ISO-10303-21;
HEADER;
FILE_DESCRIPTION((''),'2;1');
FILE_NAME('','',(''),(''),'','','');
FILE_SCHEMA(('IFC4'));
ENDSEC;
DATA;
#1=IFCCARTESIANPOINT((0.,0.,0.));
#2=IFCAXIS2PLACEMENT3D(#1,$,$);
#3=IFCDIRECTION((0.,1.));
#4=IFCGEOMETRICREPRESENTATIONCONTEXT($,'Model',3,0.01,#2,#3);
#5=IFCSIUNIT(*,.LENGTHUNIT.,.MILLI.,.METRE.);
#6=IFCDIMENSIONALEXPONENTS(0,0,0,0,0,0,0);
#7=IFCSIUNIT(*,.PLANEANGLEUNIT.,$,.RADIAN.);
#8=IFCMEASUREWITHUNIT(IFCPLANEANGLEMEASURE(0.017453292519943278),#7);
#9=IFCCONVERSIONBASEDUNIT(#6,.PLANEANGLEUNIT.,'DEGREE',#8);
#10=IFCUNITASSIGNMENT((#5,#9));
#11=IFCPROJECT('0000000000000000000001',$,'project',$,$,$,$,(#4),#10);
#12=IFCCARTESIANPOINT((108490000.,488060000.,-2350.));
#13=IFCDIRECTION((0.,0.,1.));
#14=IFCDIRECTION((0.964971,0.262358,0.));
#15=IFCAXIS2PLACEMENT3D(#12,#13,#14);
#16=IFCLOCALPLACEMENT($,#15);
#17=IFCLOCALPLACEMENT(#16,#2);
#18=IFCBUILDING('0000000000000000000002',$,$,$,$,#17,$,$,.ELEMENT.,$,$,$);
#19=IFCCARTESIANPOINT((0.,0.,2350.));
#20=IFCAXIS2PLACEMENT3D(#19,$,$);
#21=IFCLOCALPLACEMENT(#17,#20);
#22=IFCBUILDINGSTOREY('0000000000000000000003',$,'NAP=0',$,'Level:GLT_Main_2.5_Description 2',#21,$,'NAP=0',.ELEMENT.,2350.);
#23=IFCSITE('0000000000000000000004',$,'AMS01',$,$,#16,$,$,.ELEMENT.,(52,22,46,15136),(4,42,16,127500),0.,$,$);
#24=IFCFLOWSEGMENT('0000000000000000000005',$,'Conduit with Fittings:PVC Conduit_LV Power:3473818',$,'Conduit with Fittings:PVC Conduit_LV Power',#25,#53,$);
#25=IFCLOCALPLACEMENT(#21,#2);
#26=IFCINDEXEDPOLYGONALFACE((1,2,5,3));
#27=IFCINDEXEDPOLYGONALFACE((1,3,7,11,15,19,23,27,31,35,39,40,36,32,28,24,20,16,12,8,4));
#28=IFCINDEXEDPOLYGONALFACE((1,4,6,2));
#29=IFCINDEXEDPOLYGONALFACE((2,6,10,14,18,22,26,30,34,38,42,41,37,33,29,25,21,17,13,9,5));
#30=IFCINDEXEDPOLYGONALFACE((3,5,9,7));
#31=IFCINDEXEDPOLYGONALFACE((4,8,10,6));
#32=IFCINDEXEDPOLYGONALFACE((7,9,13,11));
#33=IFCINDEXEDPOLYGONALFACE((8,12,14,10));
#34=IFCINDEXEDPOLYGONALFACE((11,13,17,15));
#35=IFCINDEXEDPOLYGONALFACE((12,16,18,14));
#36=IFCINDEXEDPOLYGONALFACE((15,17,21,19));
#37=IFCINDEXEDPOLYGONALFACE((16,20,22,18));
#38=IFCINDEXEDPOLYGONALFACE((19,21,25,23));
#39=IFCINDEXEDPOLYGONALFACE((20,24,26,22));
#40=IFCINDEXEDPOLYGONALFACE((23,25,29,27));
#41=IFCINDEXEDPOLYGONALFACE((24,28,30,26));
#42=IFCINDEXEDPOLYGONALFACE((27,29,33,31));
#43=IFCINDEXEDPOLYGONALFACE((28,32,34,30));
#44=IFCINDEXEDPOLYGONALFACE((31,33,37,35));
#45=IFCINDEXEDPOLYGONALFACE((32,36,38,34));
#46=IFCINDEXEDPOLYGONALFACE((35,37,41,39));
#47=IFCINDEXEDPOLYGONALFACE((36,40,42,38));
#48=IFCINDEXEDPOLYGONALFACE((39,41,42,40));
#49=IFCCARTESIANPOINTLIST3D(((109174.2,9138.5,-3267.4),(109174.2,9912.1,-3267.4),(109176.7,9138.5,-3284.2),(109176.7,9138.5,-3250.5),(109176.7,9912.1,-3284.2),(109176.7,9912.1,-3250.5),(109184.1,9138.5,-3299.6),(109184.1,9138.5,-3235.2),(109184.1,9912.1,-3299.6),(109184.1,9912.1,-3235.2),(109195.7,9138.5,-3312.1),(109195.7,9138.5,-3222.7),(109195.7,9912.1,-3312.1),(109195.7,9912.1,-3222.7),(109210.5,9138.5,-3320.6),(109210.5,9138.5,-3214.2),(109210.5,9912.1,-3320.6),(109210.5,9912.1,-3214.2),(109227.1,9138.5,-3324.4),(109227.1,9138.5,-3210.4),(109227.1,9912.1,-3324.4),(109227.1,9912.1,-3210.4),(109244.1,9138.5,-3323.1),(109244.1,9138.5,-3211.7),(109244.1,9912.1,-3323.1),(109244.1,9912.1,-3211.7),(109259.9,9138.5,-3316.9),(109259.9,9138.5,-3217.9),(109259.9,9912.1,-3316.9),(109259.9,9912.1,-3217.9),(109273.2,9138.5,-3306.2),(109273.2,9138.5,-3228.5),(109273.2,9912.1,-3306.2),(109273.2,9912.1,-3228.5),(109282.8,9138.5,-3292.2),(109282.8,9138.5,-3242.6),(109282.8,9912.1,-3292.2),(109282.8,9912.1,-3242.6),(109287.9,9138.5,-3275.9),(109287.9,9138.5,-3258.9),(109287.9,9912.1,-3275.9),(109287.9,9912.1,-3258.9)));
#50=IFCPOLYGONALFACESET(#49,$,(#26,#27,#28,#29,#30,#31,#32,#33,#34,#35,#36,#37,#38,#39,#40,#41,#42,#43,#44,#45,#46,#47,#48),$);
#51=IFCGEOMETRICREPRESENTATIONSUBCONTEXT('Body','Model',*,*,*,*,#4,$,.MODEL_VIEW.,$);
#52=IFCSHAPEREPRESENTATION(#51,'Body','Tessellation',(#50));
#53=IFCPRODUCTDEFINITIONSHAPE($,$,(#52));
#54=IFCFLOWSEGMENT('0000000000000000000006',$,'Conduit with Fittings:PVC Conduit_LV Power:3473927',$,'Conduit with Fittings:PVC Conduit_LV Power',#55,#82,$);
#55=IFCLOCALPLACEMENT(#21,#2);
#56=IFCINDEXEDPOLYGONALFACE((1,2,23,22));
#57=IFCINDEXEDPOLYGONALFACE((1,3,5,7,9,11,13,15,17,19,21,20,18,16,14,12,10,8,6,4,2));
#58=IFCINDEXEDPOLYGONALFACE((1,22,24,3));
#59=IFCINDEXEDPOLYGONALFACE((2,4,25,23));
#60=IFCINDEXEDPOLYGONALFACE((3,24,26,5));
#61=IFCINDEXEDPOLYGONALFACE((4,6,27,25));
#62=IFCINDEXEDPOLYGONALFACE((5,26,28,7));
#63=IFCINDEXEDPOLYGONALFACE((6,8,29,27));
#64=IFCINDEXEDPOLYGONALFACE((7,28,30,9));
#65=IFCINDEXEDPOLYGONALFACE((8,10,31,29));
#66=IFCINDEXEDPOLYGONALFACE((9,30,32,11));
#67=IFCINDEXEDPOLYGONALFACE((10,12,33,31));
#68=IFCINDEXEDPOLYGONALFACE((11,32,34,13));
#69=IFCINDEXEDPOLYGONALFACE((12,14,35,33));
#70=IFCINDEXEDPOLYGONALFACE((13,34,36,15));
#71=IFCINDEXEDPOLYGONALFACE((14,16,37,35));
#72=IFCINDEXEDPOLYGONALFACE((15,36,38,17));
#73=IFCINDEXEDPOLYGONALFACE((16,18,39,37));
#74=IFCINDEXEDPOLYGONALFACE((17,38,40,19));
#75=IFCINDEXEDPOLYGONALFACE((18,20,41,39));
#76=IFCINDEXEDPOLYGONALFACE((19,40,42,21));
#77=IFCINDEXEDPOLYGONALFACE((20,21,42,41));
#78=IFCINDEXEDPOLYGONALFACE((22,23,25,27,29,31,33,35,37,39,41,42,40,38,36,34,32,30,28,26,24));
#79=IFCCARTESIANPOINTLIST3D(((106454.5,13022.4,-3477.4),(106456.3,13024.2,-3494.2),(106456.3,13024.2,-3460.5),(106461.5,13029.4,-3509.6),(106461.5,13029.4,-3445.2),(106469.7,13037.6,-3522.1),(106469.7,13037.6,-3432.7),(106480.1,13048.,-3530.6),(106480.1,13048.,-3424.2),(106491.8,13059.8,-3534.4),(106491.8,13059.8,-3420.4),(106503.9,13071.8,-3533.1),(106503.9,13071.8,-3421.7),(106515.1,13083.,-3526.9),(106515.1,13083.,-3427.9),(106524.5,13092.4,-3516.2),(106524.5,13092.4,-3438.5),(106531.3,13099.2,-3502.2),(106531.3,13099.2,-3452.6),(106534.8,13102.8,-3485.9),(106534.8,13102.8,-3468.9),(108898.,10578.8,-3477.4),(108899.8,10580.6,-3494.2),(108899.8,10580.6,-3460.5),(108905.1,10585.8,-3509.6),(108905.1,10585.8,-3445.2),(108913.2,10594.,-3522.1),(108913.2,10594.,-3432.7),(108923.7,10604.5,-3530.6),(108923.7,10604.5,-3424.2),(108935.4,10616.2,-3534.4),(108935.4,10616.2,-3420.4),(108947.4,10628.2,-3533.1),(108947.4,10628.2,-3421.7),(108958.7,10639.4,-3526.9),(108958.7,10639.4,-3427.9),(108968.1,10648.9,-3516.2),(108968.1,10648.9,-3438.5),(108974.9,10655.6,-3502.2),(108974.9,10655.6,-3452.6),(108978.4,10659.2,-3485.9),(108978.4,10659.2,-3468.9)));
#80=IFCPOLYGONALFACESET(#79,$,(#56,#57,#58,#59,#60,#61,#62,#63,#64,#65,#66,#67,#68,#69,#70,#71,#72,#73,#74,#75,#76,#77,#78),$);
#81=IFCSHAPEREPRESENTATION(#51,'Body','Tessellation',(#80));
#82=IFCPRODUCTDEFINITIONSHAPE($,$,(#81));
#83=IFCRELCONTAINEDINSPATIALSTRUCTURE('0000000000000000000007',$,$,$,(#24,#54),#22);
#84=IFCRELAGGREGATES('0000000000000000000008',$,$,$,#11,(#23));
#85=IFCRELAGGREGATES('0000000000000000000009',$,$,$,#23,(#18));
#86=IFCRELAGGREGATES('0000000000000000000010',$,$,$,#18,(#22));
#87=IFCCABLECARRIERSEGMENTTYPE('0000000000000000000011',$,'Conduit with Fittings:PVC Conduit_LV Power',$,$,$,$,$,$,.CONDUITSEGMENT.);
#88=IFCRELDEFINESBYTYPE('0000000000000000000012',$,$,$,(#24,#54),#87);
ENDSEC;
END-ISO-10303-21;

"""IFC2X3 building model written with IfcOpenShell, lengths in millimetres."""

from ifc_helpers import new_model, entity, si_unit, converted_unit, direction, frame, frame_2d, origin, place, context, subcontext, project, spatial, circle, extrude, type_object, element, save


model = new_model("IFC2X3")

# Units and contexts
model_context = context("Model", 3, precision=0.01, world=origin(), true_north=direction((0.0, 1.0)))
body_context = subcontext(model_context, "Body", "Model", "MODEL_VIEW")
ifc_project = project(units=[si_unit("LENGTHUNIT", "METRE", prefix="MILLI"), converted_unit("PLANEANGLEUNIT", "DEGREE", entity("IfcPlaneAngleMeasure", 0.017453292519943278), si_unit("PLANEANGLEUNIT", "RADIAN"), dimensions=[0, 0, 0, 0, 0, 0, 0])], contexts=[model_context])

# Site, building, storey
site_placement = place(None, frame((108490000.0, 488060000.0, -2350.0), z_axis=(0.0, 0.0, 1.0), x_axis=(0.964971, 0.262358, 0.0)))
site = spatial("IfcSite", under=ifc_project, at=site_placement, Name="AMS01", CompositionType="ELEMENT", RefLatitude=(52, 22, 46, 15136), RefLongitude=(4, 42, 16, 127500), RefElevation=0.0)
building_placement = place(site_placement, origin())
building = spatial("IfcBuilding", under=site, at=building_placement, CompositionType="ELEMENT")
storey_placement = place(building_placement, frame((0.0, 0.0, 2350.0)))
storey = spatial("IfcBuildingStorey", under=building, at=storey_placement, Name="NAP=0", ObjectType="Level:GLT_Main_2.5_Description 2", LongName="NAP=0", CompositionType="ELEMENT", Elevation=2350.0)

# Flow segments
cable_carrier_segment_type = type_object("IfcCableCarrierSegmentType", Name="Conduit with Fittings:PVC Conduit_LV Power", PredefinedType="CONDUITSEGMENT")
flow_segment_1_placement = place(storey_placement, origin())
element("IfcFlowSegment", 1, at=flow_segment_1_placement, inside=storey, type_object=cable_carrier_segment_type, Name="Conduit with Fittings:PVC Conduit_LV Power:3473818", ObjectType="Conduit with Fittings:PVC Conduit_LV Power", context=body_context, shape_type="SweptSolid", body=[
    extrude(circle(Radius=57.2, at=frame_2d((0.0, 0.0), x_axis=(1.0, 0.0))), frame((109231.3, 9138.5, -3267.4), z_axis=(0.0, 1.0, 0.0), x_axis=(-1.0, 0.0, 0.0)), (0.0, 0.0, 1.0), 773.6),
])
flow_segment_2_placement = place(storey_placement, origin())
element("IfcFlowSegment", 2, at=flow_segment_2_placement, inside=storey, type_object=cable_carrier_segment_type, Name="Conduit with Fittings:PVC Conduit_LV Power:3473927", ObjectType="Conduit with Fittings:PVC Conduit_LV Power", context=body_context, shape_type="SweptSolid", body=[
    extrude(circle(Radius=57.2, at=frame_2d((0.0, 0.0), x_axis=(1.0, 0.0))), frame((106494.9, 13062.8, -3477.4), z_axis=(0.707107, -0.707107, 0.0), x_axis=(-0.707107, -0.707107, 0.0)), (0.0, 0.0, 1.0), 3455.7),
])

save(model, "model.ifc")
